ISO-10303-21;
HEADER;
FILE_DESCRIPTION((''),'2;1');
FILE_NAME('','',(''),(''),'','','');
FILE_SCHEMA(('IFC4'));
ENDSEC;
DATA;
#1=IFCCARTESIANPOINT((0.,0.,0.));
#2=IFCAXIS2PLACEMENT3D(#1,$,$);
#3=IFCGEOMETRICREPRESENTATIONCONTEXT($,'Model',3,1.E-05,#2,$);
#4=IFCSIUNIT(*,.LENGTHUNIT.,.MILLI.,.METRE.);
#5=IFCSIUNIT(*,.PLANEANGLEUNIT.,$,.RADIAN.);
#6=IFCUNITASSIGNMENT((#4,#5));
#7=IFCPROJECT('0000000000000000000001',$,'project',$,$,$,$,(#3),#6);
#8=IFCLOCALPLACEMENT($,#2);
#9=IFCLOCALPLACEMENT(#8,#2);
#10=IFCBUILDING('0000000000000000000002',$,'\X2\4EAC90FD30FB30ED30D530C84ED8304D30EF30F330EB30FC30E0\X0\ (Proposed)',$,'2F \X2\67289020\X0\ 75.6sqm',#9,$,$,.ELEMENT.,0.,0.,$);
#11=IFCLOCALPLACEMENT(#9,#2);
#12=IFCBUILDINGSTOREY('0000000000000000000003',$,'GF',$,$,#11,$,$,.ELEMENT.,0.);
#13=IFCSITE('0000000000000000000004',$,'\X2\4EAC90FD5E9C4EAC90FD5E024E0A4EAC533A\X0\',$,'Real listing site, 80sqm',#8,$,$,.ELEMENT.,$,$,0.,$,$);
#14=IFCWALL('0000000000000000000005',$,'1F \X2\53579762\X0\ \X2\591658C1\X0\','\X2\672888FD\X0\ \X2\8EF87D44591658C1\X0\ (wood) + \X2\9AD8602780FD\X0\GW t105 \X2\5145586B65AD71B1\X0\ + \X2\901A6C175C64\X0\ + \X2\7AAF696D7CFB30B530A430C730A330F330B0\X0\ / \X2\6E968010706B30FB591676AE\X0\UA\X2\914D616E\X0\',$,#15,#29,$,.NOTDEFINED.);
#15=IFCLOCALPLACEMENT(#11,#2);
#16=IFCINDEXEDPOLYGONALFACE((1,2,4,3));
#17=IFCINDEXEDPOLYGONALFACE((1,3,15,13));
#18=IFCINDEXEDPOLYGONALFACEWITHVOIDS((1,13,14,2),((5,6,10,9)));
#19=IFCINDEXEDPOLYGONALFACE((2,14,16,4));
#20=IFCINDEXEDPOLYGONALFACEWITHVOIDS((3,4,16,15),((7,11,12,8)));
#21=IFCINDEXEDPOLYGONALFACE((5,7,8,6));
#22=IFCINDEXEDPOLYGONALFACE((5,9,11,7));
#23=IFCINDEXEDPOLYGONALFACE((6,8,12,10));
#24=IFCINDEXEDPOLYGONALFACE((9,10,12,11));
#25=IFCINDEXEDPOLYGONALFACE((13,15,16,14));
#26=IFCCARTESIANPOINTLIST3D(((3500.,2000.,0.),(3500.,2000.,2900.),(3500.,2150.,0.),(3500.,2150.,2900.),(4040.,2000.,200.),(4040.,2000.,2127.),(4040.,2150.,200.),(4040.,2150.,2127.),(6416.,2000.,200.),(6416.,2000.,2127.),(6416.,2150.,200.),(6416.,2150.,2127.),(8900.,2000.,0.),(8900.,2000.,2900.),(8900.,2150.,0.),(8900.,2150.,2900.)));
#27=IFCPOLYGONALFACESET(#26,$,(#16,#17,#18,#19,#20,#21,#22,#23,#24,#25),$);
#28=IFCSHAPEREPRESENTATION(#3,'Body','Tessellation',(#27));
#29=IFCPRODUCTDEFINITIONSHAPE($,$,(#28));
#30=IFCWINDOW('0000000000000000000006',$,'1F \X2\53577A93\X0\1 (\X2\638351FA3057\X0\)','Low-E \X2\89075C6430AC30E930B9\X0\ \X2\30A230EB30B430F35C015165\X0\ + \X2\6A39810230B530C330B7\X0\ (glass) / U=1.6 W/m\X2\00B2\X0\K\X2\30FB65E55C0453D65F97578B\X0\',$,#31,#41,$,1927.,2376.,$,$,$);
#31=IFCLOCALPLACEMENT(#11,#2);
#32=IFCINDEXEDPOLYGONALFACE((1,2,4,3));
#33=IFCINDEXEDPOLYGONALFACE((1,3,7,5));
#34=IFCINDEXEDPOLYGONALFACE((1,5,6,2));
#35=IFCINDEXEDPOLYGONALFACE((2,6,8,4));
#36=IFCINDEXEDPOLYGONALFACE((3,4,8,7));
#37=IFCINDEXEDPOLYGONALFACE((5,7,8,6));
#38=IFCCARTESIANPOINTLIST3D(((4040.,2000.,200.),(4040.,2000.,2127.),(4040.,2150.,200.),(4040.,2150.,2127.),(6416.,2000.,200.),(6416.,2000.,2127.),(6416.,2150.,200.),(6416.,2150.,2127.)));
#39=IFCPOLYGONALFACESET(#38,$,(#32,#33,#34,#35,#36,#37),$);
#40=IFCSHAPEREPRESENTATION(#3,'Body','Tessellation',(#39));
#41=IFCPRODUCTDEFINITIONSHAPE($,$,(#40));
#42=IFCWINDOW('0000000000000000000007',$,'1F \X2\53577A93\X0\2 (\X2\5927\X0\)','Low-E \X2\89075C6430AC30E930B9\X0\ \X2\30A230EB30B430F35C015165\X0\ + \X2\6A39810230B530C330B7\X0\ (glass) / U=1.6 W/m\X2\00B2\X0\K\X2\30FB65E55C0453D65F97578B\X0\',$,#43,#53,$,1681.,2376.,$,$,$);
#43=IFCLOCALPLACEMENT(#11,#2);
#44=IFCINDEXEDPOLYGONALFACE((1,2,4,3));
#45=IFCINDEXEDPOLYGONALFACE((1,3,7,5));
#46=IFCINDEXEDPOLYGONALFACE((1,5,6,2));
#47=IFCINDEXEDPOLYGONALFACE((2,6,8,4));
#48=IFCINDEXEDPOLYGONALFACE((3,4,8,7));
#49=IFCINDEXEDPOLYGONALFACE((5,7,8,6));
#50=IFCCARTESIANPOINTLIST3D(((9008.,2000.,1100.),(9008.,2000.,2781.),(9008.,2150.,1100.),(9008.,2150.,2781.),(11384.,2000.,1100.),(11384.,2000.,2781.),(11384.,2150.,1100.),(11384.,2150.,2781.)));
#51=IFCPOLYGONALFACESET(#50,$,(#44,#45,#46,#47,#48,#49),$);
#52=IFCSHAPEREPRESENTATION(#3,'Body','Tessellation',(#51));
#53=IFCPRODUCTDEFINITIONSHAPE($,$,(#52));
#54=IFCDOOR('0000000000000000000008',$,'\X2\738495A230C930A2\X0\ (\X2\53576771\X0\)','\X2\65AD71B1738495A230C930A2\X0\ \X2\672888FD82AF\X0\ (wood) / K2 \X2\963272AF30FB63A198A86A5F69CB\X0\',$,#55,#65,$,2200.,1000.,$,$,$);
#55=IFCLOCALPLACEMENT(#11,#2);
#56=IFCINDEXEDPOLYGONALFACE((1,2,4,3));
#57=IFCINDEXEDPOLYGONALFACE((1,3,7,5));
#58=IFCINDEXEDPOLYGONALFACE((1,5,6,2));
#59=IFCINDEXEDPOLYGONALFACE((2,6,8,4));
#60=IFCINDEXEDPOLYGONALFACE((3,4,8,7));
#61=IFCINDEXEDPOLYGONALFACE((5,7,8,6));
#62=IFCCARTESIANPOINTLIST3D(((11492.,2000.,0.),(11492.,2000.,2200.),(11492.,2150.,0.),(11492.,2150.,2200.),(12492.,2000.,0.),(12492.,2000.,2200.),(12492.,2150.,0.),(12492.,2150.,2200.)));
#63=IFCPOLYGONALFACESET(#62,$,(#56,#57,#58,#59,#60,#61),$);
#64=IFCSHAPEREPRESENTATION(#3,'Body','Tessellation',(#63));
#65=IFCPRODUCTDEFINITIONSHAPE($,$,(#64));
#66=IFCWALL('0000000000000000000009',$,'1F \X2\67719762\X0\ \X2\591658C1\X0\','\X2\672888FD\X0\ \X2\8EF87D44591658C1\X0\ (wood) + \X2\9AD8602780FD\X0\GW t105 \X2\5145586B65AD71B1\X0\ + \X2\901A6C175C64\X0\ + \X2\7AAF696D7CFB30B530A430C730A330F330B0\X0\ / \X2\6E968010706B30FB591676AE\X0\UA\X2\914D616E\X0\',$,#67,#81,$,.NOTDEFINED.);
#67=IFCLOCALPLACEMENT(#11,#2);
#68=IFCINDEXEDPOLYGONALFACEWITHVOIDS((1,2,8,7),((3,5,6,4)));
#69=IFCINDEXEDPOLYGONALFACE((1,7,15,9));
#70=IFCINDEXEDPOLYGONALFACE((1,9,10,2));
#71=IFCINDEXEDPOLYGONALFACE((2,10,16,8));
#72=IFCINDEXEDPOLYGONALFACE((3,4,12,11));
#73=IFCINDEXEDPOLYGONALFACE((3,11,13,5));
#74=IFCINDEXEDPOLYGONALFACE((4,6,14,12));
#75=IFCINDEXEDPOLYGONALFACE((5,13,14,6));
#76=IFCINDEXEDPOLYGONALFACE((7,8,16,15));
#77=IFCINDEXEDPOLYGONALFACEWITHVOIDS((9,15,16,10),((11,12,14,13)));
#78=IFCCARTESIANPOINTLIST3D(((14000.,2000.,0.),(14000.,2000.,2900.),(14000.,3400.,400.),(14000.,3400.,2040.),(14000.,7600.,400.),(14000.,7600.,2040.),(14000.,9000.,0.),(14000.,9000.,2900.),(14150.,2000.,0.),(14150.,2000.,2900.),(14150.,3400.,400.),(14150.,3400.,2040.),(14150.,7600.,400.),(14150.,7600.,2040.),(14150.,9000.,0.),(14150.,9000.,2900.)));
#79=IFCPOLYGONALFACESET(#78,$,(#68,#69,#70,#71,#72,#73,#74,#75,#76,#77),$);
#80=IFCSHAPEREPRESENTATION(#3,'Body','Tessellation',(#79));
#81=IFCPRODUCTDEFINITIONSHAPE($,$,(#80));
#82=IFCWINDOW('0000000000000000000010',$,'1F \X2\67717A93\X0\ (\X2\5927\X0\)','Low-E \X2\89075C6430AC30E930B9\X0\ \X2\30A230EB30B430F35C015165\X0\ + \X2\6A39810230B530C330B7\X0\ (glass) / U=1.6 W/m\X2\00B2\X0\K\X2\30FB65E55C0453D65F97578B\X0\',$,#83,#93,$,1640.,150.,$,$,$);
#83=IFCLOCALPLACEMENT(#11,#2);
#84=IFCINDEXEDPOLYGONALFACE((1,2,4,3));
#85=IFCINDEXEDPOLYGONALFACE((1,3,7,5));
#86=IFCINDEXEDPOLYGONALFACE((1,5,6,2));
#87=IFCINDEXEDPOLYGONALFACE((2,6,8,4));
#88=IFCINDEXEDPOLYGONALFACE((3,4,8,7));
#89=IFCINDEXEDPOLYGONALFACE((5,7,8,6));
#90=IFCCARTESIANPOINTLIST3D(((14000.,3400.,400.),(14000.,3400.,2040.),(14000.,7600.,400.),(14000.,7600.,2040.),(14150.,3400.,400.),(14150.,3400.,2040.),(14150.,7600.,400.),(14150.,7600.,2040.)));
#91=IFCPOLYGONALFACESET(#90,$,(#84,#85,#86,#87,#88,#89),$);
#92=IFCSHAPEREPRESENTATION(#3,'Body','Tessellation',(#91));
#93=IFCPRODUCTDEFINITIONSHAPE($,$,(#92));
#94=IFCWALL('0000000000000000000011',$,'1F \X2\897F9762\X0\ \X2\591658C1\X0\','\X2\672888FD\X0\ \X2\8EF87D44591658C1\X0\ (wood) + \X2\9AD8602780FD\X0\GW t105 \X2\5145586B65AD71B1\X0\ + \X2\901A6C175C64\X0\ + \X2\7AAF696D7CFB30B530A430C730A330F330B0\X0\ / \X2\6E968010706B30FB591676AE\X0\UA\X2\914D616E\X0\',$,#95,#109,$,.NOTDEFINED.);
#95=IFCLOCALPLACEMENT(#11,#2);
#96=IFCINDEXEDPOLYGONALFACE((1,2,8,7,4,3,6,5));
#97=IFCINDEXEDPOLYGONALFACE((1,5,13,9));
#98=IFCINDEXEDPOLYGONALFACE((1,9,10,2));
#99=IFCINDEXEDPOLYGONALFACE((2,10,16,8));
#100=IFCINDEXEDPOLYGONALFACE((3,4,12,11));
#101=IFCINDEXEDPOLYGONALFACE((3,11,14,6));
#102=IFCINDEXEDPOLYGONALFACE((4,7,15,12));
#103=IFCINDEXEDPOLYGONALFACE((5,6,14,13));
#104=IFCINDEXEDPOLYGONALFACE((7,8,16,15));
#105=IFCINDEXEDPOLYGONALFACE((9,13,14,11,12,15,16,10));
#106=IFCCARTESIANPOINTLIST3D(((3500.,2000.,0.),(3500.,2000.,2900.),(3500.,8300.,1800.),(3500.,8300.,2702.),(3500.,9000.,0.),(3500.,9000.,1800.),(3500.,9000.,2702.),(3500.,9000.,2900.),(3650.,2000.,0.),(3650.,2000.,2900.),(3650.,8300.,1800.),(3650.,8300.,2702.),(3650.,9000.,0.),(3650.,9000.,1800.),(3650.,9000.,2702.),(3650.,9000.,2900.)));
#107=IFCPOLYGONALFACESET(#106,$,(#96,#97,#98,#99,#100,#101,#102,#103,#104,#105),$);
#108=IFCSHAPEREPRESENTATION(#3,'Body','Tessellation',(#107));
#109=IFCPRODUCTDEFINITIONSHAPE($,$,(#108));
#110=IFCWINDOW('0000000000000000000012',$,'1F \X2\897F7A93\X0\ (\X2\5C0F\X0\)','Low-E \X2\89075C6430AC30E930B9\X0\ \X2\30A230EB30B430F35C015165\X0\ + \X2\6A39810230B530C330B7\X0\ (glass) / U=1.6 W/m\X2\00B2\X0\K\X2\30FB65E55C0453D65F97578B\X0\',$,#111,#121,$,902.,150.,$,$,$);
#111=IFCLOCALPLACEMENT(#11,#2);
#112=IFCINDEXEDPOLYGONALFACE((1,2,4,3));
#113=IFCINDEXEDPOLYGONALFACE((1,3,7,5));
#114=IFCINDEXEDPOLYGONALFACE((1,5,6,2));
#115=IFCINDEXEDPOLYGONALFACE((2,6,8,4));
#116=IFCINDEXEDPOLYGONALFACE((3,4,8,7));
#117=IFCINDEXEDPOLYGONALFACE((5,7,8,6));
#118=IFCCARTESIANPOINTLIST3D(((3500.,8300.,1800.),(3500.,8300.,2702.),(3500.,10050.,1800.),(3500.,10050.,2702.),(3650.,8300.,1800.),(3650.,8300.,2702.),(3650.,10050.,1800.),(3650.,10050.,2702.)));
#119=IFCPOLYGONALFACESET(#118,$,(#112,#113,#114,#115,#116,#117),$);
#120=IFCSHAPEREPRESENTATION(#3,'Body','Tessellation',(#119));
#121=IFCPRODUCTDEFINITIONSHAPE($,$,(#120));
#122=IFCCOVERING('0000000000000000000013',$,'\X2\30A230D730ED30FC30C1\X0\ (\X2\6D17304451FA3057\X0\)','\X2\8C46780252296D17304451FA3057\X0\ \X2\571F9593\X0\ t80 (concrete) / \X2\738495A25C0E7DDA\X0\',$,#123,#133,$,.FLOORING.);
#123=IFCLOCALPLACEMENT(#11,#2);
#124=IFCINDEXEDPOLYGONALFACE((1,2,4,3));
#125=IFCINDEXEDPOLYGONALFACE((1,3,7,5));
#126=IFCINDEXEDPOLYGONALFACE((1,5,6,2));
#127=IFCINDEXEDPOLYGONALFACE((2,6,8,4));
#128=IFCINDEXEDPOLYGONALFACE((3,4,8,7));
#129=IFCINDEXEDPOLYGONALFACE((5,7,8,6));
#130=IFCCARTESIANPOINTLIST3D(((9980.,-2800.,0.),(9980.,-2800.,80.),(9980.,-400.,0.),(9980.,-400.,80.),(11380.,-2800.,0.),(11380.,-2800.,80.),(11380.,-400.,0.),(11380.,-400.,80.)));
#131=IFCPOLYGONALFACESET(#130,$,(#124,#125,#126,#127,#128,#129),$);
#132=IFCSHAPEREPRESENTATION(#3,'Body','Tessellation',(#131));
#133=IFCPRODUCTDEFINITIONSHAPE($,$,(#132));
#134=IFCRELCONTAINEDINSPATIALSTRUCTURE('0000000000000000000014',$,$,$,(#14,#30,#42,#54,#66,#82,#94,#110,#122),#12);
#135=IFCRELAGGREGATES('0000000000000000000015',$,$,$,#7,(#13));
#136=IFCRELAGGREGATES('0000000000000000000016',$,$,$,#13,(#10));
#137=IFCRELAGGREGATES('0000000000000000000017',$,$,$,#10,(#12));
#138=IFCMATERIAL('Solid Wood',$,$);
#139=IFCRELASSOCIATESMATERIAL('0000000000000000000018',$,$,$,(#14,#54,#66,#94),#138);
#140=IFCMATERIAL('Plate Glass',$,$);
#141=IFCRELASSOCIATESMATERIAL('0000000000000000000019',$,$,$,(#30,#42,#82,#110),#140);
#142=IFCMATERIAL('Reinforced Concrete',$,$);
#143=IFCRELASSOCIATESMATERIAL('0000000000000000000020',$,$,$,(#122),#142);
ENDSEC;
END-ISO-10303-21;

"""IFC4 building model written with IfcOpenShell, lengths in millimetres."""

from ifc_helpers import new_model, si_unit, frame, frame_2d, origin, place, context, project, spatial, rectangle, extrude, material, element, fill, save


model = new_model("IFC4")

# Units and contexts
model_context = context("Model", 3, precision=1e-05, world=origin())
ifc_project = project(units=[si_unit("LENGTHUNIT", "METRE", prefix="MILLI"), si_unit("PLANEANGLEUNIT", "RADIAN")], contexts=[model_context])

# Site, building, storey
site_placement = place(None, origin())
site = spatial("IfcSite", under=ifc_project, at=site_placement, Name="京都府京都市上京区", ObjectType="Real listing site, 80sqm", CompositionType="ELEMENT", RefElevation=0.0)
building_placement = place(site_placement, origin())
building = spatial("IfcBuilding", under=site, at=building_placement, Name="京都・ロフト付きワンルーム (Proposed)", ObjectType="2F 木造 75.6sqm", CompositionType="ELEMENT", ElevationOfRefHeight=0.0, ElevationOfTerrain=0.0)
storey_placement = place(building_placement, origin())
storey = spatial("IfcBuildingStorey", under=building, at=storey_placement, Name="GF", CompositionType="ELEMENT", Elevation=0.0)

# Shared definitions
ifc_material_1 = material(Name="Solid Wood")

# Shared definitions
ifc_material_2 = material(Name="Reinforced Concrete")

# Wall, openings, windows, door
wall_1_placement = place(storey_placement, frame((1750.0, 1000.0, 0.0)))
wall_1 = element("IfcWall", 1, at=wall_1_placement, inside=storey, material=ifc_material_1, Name="1F 南面 外壁", Description="木製 軸組外壁 (wood) + 高性能GW t105 充填断熱 + 通気層 + 窯業系サイディング / 準耐火・外皮UA配慮", PredefinedType="NOTDEFINED", context=model_context, shape_type="SweptSolid", body=[
    extrude(rectangle(XDim=5400.0, YDim=150.0, at=frame_2d((2700.0, 75.0))), frame((1750.0, 1000.0, 0.0)), (0.0, 0.0, 1.0), 2900.0),
])
opening_1_placement = place(storey_placement, frame((2020.0, 1000.0, 100.0)))
opening_1 = element("IfcOpeningElement", 2, at=opening_1_placement, cuts=wall_1, PredefinedType="NOTDEFINED", context=model_context, shape_type="SweptSolid", body=[
    extrude(rectangle(XDim=2376.0, YDim=150.0, at=frame_2d((1188.0, 75.0))), frame((2020.0, 1000.0, 100.0)), (0.0, 0.0, 1.0), 1927.0),
])
opening_2_placement = place(storey_placement, frame((4504.0, 1000.0, 550.0)))
opening_2 = element("IfcOpeningElement", 3, at=opening_2_placement, cuts=wall_1, PredefinedType="NOTDEFINED", context=model_context, shape_type="SweptSolid", body=[
    extrude(rectangle(XDim=2376.0, YDim=150.0, at=frame_2d((1188.0, 75.0))), frame((4504.0, 1000.0, 550.0)), (0.0, 0.0, 1.0), 1681.0),
])
opening_3_placement = place(storey_placement, frame((5746.0, 1000.0, 0.0)))
opening_3 = element("IfcOpeningElement", 4, at=opening_3_placement, cuts=wall_1, PredefinedType="NOTDEFINED", context=model_context, shape_type="SweptSolid", body=[
    extrude(rectangle(XDim=1000.0, YDim=150.0, at=frame_2d((500.0, 75.0))), frame((5746.0, 1000.0, 0.0)), (0.0, 0.0, 1.0), 2200.0),
])
ifc_material_3 = material(Name="Plate Glass")
window_1_placement = place(storey_placement, frame((2020.0, 1000.0, 100.0)))
window_1 = element("IfcWindow", 5, at=window_1_placement, inside=storey, material=ifc_material_3, Name="1F 南窓1 (掃出し)", Description="Low-E 複層ガラス アルゴン封入 + 樹脂サッシ (glass) / U=1.6 W/m²K・日射取得型", OverallHeight=1927.0, OverallWidth=2376.0, context=model_context, shape_type="SweptSolid", body=[
    extrude(rectangle(XDim=2376.0, YDim=150.0, at=frame_2d((1188.0, 75.0))), frame((2020.0, 1000.0, 100.0)), (0.0, 0.0, 1.0), 1927.0),
])
fill(opening_1, window_1)
window_2_placement = place(storey_placement, frame((4504.0, 1000.0, 550.0)))
window_2 = element("IfcWindow", 6, at=window_2_placement, inside=storey, material=ifc_material_3, Name="1F 南窓2 (大)", Description="Low-E 複層ガラス アルゴン封入 + 樹脂サッシ (glass) / U=1.6 W/m²K・日射取得型", OverallHeight=1681.0, OverallWidth=2376.0, context=model_context, shape_type="SweptSolid", body=[
    extrude(rectangle(XDim=2376.0, YDim=150.0, at=frame_2d((1188.0, 75.0))), frame((4504.0, 1000.0, 550.0)), (0.0, 0.0, 1.0), 1681.0),
])
fill(opening_2, window_2)
door_placement = place(storey_placement, frame((5746.0, 1000.0, 0.0)))
door = element("IfcDoor", 7, at=door_placement, inside=storey, material=ifc_material_1, Name="玄関ドア (南東)", Description="断熱玄関ドア 木製芯 (wood) / K2 防犯・採風機構", OverallHeight=2200.0, OverallWidth=1000.0, context=model_context, shape_type="SweptSolid", body=[
    extrude(rectangle(XDim=1000.0, YDim=150.0, at=frame_2d((500.0, 75.0))), frame((5746.0, 1000.0, 0.0)), (0.0, 0.0, 1.0), 2200.0),
])
fill(opening_3, door)

# Walls, openings, windows
wall_2_placement = place(storey_placement, frame((7000.0, 1000.0, 0.0)))
wall_2 = element("IfcWall", 8, at=wall_2_placement, inside=storey, material=ifc_material_1, Name="1F 東面 外壁", Description="木製 軸組外壁 (wood) + 高性能GW t105 充填断熱 + 通気層 + 窯業系サイディング / 準耐火・外皮UA配慮", PredefinedType="NOTDEFINED", context=model_context, shape_type="SweptSolid", body=[
    extrude(rectangle(XDim=150.0, YDim=7000.0, at=frame_2d((75.0, 3500.0))), frame((7000.0, 1000.0, 0.0)), (0.0, 0.0, 1.0), 2900.0),
])
opening_4_placement = place(storey_placement, frame((7000.0, 1700.0, 200.0)))
opening_4 = element("IfcOpeningElement", 9, at=opening_4_placement, cuts=wall_2, PredefinedType="NOTDEFINED", context=model_context, shape_type="SweptSolid", body=[
    extrude(rectangle(XDim=150.0, YDim=4200.0, at=frame_2d((75.0, 2100.0))), frame((7000.0, 1700.0, 200.0)), (0.0, 0.0, 1.0), 1640.0),
])
window_3_placement = place(storey_placement, frame((7000.0, 1700.0, 200.0)))
window_3 = element("IfcWindow", 10, at=window_3_placement, inside=storey, material=ifc_material_3, Name="1F 東窓 (大)", Description="Low-E 複層ガラス アルゴン封入 + 樹脂サッシ (glass) / U=1.6 W/m²K・日射取得型", OverallHeight=1640.0, OverallWidth=150.0, context=model_context, shape_type="SweptSolid", body=[
    extrude(rectangle(XDim=150.0, YDim=4200.0, at=frame_2d((75.0, 2100.0))), frame((7000.0, 1700.0, 200.0)), (0.0, 0.0, 1.0), 1640.0),
])
fill(opening_4, window_3)
wall_3_placement = place(storey_placement, frame((1750.0, 1000.0, 0.0)))
wall_3 = element("IfcWall", 11, at=wall_3_placement, inside=storey, material=ifc_material_1, Name="1F 西面 外壁", Description="木製 軸組外壁 (wood) + 高性能GW t105 充填断熱 + 通気層 + 窯業系サイディング / 準耐火・外皮UA配慮", PredefinedType="NOTDEFINED", context=model_context, shape_type="SweptSolid", body=[
    extrude(rectangle(XDim=150.0, YDim=7000.0, at=frame_2d((75.0, 3500.0))), frame((1750.0, 1000.0, 0.0)), (0.0, 0.0, 1.0), 2900.0),
])
opening_5_placement = place(storey_placement, frame((1750.0, 4150.0, 900.0)))
opening_5 = element("IfcOpeningElement", 12, at=opening_5_placement, cuts=wall_3, PredefinedType="NOTDEFINED", context=model_context, shape_type="SweptSolid", body=[
    extrude(rectangle(XDim=150.0, YDim=1750.0, at=frame_2d((75.0, 875.0))), frame((1750.0, 4150.0, 900.0)), (0.0, 0.0, 1.0), 902.0),
])
window_4_placement = place(storey_placement, frame((1750.0, 4150.0, 900.0)))
window_4 = element("IfcWindow", 13, at=window_4_placement, inside=storey, material=ifc_material_3, Name="1F 西窓 (小)", Description="Low-E 複層ガラス アルゴン封入 + 樹脂サッシ (glass) / U=1.6 W/m²K・日射取得型", OverallHeight=902.0, OverallWidth=150.0, context=model_context, shape_type="SweptSolid", body=[
    extrude(rectangle(XDim=150.0, YDim=1750.0, at=frame_2d((75.0, 875.0))), frame((1750.0, 4150.0, 900.0)), (0.0, 0.0, 1.0), 902.0),
])
fill(opening_5, window_4)

# Covering
covering_1_placement = place(storey_placement, frame((4990.0, -1400.0, 0.0)))
element("IfcCovering", 14, at=covering_1_placement, inside=storey, material=ifc_material_2, Name="アプローチ (洗い出し)", Description="豆砂利洗い出し 土間 t80 (concrete) / 玄関導線", PredefinedType="FLOORING", context=model_context, shape_type="SweptSolid", body=[
    extrude(rectangle(XDim=1400.0, YDim=2400.0, at=frame_2d((700.0, 1200.0))), frame((4990.0, -1400.0, 0.0)), (0.0, 0.0, 1.0), 80.0),
])

save(model, "model.ifc")
